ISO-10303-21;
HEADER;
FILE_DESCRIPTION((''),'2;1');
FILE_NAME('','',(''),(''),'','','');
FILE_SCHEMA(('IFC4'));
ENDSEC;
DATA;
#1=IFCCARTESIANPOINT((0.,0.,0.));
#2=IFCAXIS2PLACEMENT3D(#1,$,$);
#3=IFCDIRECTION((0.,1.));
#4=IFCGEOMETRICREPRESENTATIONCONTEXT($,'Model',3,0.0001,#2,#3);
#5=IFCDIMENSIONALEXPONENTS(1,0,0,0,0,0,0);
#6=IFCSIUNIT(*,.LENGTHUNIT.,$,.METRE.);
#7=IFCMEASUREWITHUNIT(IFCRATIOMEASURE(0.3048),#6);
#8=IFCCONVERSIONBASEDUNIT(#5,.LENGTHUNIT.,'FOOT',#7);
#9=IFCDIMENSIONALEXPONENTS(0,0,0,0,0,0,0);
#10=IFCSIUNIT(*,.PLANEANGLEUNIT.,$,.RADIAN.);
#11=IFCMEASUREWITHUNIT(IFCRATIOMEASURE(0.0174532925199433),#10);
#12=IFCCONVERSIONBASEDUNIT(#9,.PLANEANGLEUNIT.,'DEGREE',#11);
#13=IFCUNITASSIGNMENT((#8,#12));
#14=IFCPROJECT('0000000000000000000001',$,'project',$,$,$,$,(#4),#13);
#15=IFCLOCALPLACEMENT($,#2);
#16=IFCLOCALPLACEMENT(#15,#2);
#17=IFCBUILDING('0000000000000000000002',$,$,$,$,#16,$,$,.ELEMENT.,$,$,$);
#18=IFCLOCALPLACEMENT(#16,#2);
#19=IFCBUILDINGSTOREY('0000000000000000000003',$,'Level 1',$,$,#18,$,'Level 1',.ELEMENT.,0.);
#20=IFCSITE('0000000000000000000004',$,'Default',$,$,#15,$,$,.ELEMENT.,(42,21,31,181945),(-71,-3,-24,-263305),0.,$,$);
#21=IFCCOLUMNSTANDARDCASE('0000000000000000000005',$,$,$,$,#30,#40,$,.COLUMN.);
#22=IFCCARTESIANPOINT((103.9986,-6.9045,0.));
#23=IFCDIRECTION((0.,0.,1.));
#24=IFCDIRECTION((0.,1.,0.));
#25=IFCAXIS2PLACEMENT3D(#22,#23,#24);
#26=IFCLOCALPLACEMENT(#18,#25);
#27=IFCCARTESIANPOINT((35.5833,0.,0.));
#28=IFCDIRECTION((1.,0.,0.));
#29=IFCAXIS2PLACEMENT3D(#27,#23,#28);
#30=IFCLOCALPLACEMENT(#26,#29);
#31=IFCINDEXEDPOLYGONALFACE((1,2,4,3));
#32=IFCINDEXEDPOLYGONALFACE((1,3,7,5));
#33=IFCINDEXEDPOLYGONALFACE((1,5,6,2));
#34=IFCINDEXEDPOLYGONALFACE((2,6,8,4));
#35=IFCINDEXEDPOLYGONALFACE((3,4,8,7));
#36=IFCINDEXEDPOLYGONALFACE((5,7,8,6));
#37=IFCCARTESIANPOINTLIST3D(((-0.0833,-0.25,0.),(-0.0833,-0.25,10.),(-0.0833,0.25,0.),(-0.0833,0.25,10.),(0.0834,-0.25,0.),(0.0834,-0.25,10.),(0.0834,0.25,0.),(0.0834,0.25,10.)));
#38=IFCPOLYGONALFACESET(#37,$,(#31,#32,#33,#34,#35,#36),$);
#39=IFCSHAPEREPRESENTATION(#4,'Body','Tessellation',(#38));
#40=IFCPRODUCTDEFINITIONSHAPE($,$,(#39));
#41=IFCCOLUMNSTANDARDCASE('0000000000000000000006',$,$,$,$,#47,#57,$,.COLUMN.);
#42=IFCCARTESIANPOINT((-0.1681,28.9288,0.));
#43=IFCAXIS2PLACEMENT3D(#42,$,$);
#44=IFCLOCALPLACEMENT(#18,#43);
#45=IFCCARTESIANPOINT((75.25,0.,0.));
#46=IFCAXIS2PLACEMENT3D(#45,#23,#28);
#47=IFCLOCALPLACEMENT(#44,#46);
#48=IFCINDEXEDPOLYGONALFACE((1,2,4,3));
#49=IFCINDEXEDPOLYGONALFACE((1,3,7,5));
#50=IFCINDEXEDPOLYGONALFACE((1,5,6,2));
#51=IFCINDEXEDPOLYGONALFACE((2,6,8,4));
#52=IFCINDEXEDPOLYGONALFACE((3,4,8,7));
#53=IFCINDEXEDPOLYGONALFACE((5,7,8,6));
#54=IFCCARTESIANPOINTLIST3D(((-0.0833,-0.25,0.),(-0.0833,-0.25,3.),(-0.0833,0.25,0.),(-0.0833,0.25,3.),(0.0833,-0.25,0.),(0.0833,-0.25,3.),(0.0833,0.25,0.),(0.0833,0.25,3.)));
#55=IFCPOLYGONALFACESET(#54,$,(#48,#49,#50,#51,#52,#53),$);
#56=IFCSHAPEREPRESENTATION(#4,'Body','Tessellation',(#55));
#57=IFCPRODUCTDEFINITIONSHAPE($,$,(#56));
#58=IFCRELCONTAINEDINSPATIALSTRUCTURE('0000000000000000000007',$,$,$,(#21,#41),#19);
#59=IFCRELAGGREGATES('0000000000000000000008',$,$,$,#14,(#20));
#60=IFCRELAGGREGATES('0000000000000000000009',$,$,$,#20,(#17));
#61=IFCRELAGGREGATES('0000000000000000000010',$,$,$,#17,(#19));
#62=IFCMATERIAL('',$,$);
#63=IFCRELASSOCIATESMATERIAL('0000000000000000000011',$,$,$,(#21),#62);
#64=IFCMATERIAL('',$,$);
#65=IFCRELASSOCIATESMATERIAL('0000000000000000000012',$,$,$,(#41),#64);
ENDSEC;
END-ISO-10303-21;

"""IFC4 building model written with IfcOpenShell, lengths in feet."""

from ifc_helpers import new_model, entity, si_unit, converted_unit, direction, frame, origin, place, context, project, spatial, rectangle, extrude, material, element, save


model = new_model("IFC4")

# Units and contexts
model_context = context("Model", 3, precision=0.0001, world=origin(), true_north=direction((0.0, 1.0)))
ifc_project = project(units=[converted_unit("LENGTHUNIT", "FOOT", entity("IfcRatioMeasure", 0.3048), si_unit("LENGTHUNIT", "METRE"), dimensions=[1, 0, 0, 0, 0, 0, 0]), converted_unit("PLANEANGLEUNIT", "DEGREE", entity("IfcRatioMeasure", 0.0174532925199433), si_unit("PLANEANGLEUNIT", "RADIAN"), dimensions=[0, 0, 0, 0, 0, 0, 0])], contexts=[model_context])

# Site, building, storey
site_placement = place(None, origin())
site = spatial("IfcSite", under=ifc_project, at=site_placement, Name="Default", CompositionType="ELEMENT", RefLatitude=(42, 21, 31, 181945), RefLongitude=(-71, -3, -24, -263305), RefElevation=0.0)
building_placement = place(site_placement, origin())
building = spatial("IfcBuilding", under=site, at=building_placement, CompositionType="ELEMENT")
storey_placement = place(building_placement, origin())
storey = spatial("IfcBuildingStorey", under=building, at=storey_placement, Name="Level 1", LongName="Level 1", CompositionType="ELEMENT", Elevation=0.0)

# Columns
ifc_material_1 = material(Name="")
placement_1 = place(storey_placement, frame((103.9986, -6.9045, 0.0), z_axis=(0.0, 0.0, 1.0), x_axis=(0.0, 1.0, 0.0)))
for number, where, z_axis, x_axis in (
    (1, (35.5833, 0.0, 0.0), (0.0, 0.0, 1.0), (1.0, 0.0, 0.0)),
):
    element("IfcColumnStandardCase", number, at=place(placement_1, frame(where, z_axis=z_axis, x_axis=x_axis)), inside=storey, material=ifc_material_1, PredefinedType="COLUMN", context=model_context, shape_type="SweptSolid", body=[
        extrude(rectangle(XDim=0.1667, YDim=0.5), origin(), (0.0, 0.0, 1.0), 10.0),
    ])
ifc_material_2 = material(Name="")
placement_2 = place(storey_placement, frame((-0.1681, 28.9288, 0.0)))
for number, where, z_axis, x_axis in (
    (2, (75.25, 0.0, 0.0), (0.0, 0.0, 1.0), (1.0, 0.0, 0.0)),
):
    element("IfcColumnStandardCase", number, at=place(placement_2, frame(where, z_axis=z_axis, x_axis=x_axis)), inside=storey, material=ifc_material_2, PredefinedType="COLUMN", context=model_context, shape_type="SweptSolid", body=[
        extrude(rectangle(XDim=0.1667, YDim=0.5), origin(), (0.0, 0.0, 1.0), 3.0),
    ])

save(model, "model.ifc")
